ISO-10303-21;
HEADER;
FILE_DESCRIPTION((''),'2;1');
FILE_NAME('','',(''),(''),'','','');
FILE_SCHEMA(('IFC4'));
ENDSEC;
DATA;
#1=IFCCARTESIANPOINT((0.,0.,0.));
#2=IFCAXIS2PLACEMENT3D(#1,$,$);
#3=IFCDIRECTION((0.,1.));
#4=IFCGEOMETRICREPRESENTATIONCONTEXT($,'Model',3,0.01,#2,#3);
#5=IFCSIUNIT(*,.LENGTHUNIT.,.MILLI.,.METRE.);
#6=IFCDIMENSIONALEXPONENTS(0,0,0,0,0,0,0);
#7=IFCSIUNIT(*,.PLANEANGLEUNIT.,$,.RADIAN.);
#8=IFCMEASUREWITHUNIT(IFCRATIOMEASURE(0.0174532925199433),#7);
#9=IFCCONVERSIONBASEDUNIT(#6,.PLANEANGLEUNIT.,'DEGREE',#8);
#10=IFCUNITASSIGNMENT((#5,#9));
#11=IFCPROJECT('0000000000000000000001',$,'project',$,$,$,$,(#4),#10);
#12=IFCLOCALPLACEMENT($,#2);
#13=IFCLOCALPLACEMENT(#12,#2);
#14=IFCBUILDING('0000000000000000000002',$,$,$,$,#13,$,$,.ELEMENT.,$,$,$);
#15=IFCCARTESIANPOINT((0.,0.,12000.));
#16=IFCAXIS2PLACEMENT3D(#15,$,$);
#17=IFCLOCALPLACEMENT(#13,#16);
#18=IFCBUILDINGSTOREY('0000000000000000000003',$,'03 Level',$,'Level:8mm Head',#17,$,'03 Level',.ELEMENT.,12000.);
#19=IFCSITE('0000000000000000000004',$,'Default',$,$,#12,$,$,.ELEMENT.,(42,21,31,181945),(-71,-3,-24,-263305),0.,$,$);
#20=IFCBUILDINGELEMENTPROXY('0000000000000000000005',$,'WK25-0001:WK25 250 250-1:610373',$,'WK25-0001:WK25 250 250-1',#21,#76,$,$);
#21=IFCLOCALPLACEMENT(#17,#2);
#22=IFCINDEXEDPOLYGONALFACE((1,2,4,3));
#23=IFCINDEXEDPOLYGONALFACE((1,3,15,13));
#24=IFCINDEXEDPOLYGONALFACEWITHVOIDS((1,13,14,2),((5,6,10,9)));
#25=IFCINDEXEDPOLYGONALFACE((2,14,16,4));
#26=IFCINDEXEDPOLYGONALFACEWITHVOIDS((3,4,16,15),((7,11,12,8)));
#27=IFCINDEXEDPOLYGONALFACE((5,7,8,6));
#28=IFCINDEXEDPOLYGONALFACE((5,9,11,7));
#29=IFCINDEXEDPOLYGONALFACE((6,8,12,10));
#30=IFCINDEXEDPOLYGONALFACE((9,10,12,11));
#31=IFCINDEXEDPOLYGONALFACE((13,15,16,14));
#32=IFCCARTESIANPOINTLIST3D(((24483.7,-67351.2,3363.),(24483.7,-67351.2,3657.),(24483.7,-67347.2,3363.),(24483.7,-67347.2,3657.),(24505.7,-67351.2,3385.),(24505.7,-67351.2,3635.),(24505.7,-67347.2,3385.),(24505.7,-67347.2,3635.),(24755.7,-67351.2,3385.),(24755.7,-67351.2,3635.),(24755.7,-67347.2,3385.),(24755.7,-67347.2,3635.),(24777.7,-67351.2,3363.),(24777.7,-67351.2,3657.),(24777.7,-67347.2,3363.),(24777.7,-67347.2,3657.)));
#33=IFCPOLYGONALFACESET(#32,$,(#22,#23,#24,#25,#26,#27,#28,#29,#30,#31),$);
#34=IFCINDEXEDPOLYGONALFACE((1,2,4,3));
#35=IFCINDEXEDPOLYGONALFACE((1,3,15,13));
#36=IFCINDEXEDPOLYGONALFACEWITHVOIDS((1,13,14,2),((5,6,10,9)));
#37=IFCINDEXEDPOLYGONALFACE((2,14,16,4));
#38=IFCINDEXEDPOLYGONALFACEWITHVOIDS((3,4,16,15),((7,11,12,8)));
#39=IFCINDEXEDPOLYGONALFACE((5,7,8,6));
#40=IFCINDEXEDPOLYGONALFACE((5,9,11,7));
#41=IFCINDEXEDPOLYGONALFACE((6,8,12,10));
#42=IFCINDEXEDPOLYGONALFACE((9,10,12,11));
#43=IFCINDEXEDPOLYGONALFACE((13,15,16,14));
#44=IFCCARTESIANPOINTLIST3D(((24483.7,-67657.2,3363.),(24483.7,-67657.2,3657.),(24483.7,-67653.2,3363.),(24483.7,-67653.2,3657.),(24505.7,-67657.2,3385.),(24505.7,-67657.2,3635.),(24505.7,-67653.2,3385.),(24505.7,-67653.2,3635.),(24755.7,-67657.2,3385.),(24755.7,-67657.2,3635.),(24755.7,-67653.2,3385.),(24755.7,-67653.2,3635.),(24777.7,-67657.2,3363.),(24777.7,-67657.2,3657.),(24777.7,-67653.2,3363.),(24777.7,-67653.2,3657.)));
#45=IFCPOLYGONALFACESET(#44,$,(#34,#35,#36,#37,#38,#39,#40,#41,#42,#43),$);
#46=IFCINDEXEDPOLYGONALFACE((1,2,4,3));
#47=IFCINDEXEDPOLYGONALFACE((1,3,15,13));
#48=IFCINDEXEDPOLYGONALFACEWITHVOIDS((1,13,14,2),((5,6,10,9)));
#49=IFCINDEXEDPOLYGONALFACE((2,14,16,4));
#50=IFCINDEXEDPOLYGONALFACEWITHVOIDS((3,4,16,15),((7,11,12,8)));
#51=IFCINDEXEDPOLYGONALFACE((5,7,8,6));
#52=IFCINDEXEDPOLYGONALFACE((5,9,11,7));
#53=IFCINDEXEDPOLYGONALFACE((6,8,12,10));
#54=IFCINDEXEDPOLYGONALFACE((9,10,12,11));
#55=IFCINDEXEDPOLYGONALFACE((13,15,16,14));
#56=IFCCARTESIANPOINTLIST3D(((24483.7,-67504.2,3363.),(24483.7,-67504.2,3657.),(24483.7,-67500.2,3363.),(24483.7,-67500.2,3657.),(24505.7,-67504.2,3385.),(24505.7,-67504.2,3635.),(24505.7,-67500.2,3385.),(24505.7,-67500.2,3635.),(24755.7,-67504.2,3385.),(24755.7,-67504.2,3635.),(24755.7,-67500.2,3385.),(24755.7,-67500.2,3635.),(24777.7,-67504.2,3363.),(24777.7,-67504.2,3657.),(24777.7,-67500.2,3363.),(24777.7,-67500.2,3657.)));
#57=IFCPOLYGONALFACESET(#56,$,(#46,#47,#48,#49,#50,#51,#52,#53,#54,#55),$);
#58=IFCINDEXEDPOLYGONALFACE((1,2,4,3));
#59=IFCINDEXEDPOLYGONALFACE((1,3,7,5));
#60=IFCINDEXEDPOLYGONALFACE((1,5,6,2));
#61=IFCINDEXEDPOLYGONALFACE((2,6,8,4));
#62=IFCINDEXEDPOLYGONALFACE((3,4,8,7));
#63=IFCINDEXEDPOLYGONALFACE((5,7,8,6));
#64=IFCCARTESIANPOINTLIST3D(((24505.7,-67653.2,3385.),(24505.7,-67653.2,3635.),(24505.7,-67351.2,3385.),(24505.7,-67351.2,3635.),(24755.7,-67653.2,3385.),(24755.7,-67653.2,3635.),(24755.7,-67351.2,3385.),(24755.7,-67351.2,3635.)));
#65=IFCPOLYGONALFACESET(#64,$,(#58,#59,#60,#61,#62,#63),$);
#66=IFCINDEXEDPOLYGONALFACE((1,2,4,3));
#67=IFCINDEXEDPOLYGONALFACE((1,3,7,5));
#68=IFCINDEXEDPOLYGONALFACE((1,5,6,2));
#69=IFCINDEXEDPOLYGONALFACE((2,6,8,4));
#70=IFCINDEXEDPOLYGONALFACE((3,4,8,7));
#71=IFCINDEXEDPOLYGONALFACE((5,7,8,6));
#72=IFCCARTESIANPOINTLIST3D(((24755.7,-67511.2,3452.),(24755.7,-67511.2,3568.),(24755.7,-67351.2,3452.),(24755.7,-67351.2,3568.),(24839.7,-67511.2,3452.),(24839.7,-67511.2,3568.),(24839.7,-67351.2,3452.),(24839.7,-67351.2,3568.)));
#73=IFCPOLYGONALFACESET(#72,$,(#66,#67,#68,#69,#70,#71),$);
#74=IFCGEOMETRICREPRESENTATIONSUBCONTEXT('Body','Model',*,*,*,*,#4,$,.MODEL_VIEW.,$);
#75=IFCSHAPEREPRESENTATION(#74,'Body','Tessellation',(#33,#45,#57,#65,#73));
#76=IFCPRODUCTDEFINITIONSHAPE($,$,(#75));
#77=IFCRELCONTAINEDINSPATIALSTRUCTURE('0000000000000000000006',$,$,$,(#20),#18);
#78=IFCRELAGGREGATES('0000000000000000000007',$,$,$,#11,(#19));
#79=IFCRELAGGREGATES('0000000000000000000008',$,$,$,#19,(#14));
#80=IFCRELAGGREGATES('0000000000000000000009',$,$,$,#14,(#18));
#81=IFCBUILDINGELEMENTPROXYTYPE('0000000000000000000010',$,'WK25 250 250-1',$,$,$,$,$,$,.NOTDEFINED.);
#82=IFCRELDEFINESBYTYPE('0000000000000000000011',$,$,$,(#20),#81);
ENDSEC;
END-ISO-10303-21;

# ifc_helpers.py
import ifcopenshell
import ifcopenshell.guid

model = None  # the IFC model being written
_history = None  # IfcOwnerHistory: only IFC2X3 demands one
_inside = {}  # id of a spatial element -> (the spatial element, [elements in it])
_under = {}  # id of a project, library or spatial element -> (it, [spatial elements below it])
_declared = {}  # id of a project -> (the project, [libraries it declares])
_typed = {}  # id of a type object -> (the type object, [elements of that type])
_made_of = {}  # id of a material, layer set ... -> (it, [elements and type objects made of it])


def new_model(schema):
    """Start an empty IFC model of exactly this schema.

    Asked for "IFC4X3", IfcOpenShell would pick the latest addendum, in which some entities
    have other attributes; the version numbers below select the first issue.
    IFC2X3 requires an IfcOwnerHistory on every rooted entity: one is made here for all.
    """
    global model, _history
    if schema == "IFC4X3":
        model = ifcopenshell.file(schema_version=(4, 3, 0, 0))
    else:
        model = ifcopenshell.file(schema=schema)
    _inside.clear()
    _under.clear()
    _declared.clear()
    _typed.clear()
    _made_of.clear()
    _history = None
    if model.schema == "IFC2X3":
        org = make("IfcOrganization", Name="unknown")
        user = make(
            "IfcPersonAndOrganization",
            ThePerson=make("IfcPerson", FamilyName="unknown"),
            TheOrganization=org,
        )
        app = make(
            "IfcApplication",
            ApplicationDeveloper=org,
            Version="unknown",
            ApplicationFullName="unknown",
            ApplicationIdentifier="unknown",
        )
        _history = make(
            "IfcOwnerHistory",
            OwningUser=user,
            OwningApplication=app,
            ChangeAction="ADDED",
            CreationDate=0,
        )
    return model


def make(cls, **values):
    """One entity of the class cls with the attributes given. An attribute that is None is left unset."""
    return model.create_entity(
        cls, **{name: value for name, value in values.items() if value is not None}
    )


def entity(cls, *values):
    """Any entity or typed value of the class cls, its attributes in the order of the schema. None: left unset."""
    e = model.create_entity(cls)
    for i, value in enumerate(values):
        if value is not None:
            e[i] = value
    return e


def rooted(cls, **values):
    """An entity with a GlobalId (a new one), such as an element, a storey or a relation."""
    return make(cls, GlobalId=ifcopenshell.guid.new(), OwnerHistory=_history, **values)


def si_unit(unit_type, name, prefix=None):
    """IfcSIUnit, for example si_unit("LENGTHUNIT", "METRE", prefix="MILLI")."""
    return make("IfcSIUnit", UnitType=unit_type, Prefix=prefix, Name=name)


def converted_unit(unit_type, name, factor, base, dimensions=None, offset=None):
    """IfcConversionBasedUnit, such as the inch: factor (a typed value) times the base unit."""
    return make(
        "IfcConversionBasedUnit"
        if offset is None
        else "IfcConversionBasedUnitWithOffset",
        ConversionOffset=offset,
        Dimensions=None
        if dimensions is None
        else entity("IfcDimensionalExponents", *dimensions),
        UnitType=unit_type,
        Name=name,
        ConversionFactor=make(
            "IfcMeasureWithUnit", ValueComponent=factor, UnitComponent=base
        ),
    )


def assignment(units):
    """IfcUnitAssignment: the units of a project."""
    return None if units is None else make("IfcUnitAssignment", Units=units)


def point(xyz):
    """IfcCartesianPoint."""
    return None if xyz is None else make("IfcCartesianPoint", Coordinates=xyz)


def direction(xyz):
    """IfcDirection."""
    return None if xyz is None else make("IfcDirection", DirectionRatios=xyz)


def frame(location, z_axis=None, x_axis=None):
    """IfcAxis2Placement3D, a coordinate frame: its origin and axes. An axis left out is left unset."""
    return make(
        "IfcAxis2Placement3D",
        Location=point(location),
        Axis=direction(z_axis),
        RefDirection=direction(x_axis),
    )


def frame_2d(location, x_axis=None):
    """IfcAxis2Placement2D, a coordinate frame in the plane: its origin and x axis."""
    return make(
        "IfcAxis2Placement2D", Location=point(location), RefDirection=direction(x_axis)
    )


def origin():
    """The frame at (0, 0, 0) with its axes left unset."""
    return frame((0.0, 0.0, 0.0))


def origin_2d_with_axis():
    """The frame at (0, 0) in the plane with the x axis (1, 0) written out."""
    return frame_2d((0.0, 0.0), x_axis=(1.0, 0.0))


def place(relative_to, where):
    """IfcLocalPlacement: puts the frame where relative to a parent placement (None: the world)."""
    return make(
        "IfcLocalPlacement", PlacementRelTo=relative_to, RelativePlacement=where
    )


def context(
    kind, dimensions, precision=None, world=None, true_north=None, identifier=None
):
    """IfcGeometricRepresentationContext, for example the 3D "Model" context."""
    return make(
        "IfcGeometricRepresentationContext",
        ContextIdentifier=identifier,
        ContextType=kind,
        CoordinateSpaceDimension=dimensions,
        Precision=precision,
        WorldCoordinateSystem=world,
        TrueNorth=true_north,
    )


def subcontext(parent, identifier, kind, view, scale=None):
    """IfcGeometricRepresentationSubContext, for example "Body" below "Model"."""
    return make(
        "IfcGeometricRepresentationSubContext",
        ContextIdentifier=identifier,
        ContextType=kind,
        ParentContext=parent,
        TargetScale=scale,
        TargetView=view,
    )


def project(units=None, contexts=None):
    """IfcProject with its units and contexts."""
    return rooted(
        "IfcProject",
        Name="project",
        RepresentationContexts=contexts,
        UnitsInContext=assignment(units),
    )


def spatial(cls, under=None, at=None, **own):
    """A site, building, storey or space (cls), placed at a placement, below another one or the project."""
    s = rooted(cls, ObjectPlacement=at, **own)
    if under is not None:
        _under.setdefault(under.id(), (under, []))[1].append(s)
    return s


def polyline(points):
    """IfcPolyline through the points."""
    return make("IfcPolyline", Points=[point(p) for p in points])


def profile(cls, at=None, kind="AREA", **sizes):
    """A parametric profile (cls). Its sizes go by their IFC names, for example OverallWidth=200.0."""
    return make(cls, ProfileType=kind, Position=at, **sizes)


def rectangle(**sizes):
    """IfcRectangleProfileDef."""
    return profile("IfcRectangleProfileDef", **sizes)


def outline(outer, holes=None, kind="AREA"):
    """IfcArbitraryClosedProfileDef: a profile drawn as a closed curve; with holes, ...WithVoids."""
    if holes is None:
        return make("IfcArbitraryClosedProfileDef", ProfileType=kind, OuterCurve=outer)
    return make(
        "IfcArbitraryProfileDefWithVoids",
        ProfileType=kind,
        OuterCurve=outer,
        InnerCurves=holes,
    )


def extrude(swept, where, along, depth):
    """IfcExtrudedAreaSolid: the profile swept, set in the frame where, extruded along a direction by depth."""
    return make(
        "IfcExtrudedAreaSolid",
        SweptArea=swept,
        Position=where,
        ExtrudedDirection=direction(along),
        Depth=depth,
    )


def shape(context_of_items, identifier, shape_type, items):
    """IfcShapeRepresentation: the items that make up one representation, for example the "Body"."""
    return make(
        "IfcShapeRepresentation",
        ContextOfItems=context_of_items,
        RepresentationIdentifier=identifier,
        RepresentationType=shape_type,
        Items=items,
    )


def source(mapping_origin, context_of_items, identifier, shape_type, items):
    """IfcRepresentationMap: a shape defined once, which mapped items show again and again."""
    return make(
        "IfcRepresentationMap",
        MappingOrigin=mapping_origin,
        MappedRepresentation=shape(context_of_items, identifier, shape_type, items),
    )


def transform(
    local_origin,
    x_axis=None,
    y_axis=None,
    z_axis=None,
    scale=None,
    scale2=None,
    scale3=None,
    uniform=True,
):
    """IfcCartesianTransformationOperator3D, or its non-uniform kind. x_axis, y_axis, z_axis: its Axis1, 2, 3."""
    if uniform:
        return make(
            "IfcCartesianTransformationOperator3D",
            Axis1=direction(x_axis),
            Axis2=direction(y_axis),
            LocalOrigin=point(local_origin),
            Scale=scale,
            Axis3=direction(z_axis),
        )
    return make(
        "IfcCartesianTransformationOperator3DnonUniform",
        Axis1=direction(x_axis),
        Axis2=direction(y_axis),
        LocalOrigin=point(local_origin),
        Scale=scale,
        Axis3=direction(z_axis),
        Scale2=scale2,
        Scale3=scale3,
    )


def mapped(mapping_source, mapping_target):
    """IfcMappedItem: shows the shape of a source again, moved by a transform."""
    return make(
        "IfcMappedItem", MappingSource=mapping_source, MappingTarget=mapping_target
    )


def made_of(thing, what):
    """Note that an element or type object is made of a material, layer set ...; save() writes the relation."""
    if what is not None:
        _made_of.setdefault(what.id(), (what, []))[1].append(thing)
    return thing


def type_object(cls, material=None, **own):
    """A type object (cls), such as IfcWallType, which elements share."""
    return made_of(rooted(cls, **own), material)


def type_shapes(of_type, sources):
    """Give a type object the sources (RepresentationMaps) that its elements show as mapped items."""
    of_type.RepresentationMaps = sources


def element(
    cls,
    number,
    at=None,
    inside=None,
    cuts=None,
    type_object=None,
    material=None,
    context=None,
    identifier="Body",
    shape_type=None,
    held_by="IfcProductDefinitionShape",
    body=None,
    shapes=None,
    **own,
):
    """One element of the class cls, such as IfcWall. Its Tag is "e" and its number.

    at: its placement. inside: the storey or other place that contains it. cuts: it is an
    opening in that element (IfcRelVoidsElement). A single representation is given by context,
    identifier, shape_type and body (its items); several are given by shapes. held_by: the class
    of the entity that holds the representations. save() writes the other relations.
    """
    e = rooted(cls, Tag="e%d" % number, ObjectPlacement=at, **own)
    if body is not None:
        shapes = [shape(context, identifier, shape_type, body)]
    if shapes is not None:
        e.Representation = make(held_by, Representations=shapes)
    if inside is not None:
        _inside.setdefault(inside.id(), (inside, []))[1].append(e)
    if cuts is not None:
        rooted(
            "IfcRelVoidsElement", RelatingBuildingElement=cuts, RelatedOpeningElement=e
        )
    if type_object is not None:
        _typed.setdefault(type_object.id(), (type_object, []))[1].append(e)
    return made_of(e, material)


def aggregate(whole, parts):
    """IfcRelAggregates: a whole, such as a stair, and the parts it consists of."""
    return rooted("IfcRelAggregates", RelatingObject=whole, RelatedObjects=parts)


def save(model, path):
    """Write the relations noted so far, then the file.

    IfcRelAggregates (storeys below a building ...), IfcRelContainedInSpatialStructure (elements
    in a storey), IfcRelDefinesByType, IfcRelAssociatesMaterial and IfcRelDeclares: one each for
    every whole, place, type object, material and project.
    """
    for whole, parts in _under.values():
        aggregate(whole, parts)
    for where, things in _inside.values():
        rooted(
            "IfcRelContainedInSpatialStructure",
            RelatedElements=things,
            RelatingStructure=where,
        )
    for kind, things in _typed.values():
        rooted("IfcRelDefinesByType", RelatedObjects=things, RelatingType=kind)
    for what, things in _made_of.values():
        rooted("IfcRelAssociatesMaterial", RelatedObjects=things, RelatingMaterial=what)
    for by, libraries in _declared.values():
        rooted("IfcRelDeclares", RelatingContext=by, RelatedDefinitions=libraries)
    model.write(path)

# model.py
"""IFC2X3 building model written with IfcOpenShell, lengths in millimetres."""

from ifc_helpers import new_model, entity, si_unit, converted_unit, direction, frame, frame_2d, origin, origin_2d_with_axis, place, context, subcontext, project, spatial, polyline, rectangle, outline, extrude, source, transform, mapped, type_object, type_shapes, element, save


model = new_model("IFC2X3")

# Units and contexts
model_context = context("Model", 3, precision=0.01, world=origin(), true_north=direction((0.0, 1.0)))
body_context = subcontext(model_context, "Body", "Model", "MODEL_VIEW")
ifc_project = project(units=[si_unit("LENGTHUNIT", "METRE", prefix="MILLI"), converted_unit("PLANEANGLEUNIT", "DEGREE", entity("IfcRatioMeasure", 0.0174532925199433), si_unit("PLANEANGLEUNIT", "RADIAN"), dimensions=[0, 0, 0, 0, 0, 0, 0])], contexts=[model_context])

# Site, building, storey
site_placement = place(None, origin())
site = spatial("IfcSite", under=ifc_project, at=site_placement, Name="Default", CompositionType="ELEMENT", RefLatitude=(42, 21, 31, 181945), RefLongitude=(-71, -3, -24, -263305), RefElevation=0.0)
building_placement = place(site_placement, origin())
building = spatial("IfcBuilding", under=site, at=building_placement, CompositionType="ELEMENT")
storey_placement = place(building_placement, frame((0.0, 0.0, 12000.0)))
storey = spatial("IfcBuildingStorey", under=building, at=storey_placement, Name="03 Level", ObjectType="Level:8mm Head", LongName="03 Level", CompositionType="ELEMENT", Elevation=12000.0)

# Building element proxy
building_element_proxy_type_1 = type_object("IfcBuildingElementProxyType", Name="WK25 250 250-1", PredefinedType="NOTDEFINED")
shared_shape_1 = source(origin(), body_context, "Body", "SweptSolid", [
    extrude(outline(polyline([(-147.0, -147.0), (147.0, -147.0), (147.0, 147.0), (-147.0, 147.0), (-147.0, -147.0)]), holes=[polyline([(-125.0, -125.0), (-125.0, 125.0), (125.0, 125.0), (125.0, -125.0), (-125.0, -125.0)])]), frame((151.0, 0.0, 0.0), z_axis=(1.0, 0.0, 0.0), x_axis=(0.0, -1.0, 0.0)), (0.0, 0.0, 1.0), 4.0),
    extrude(outline(polyline([(-147.0, -147.0), (147.0, -147.0), (147.0, 147.0), (-147.0, 147.0), (-147.0, -147.0)]), holes=[polyline([(-125.0, -125.0), (-125.0, 125.0), (125.0, 125.0), (125.0, -125.0), (-125.0, -125.0)])]), frame((-155.0, 0.0, 0.0), z_axis=(1.0, 0.0, 0.0), x_axis=(0.0, 0.0, -1.0)), (0.0, 0.0, 1.0), 4.0),
    extrude(outline(polyline([(-147.0, -147.0), (147.0, -147.0), (147.0, 147.0), (-147.0, 147.0), (-147.0, -147.0)]), holes=[polyline([(-125.0, -125.0), (-125.0, 125.0), (125.0, 125.0), (125.0, -125.0), (-125.0, -125.0)])]), frame((-2.0, 0.0, 0.0), z_axis=(1.0, 0.0, 0.0), x_axis=(0.0, 0.0, -1.0)), (0.0, 0.0, 1.0), 4.0),
    extrude(rectangle(XDim=250.0, YDim=302.0, at=origin_2d_with_axis()), frame((0.0, 0.0, -125.0), z_axis=(0.0, 0.0, 1.0), x_axis=(0.0, 1.0, 0.0)), (0.0, 0.0, 1.0), 250.0),
    extrude(rectangle(XDim=160.0, YDim=84.0, at=frame_2d((0.0, 0.0), x_axis=(1.0, 0.0))), frame((71.0, 167.0, -58.0)), (0.0, 0.0, 1.0), 116.0),
])
type_shapes(building_element_proxy_type_1, [shared_shape_1])
proxy_1_placement = place(storey_placement, frame((24630.7, -67502.2, 3510.0), z_axis=(0.0, 0.0, -1.0), x_axis=(0.0, 1.0, 0.0)))
element("IfcBuildingElementProxy", 1, at=proxy_1_placement, inside=storey, type_object=building_element_proxy_type_1, Name="WK25-0001:WK25 250 250-1:610373", ObjectType="WK25-0001:WK25 250 250-1", context=body_context, shape_type="MappedRepresentation", body=[
    mapped(shared_shape_1, transform((0.0, 0.0, 0.0), scale=1.0)),
])

save(model, "model.ifc")
